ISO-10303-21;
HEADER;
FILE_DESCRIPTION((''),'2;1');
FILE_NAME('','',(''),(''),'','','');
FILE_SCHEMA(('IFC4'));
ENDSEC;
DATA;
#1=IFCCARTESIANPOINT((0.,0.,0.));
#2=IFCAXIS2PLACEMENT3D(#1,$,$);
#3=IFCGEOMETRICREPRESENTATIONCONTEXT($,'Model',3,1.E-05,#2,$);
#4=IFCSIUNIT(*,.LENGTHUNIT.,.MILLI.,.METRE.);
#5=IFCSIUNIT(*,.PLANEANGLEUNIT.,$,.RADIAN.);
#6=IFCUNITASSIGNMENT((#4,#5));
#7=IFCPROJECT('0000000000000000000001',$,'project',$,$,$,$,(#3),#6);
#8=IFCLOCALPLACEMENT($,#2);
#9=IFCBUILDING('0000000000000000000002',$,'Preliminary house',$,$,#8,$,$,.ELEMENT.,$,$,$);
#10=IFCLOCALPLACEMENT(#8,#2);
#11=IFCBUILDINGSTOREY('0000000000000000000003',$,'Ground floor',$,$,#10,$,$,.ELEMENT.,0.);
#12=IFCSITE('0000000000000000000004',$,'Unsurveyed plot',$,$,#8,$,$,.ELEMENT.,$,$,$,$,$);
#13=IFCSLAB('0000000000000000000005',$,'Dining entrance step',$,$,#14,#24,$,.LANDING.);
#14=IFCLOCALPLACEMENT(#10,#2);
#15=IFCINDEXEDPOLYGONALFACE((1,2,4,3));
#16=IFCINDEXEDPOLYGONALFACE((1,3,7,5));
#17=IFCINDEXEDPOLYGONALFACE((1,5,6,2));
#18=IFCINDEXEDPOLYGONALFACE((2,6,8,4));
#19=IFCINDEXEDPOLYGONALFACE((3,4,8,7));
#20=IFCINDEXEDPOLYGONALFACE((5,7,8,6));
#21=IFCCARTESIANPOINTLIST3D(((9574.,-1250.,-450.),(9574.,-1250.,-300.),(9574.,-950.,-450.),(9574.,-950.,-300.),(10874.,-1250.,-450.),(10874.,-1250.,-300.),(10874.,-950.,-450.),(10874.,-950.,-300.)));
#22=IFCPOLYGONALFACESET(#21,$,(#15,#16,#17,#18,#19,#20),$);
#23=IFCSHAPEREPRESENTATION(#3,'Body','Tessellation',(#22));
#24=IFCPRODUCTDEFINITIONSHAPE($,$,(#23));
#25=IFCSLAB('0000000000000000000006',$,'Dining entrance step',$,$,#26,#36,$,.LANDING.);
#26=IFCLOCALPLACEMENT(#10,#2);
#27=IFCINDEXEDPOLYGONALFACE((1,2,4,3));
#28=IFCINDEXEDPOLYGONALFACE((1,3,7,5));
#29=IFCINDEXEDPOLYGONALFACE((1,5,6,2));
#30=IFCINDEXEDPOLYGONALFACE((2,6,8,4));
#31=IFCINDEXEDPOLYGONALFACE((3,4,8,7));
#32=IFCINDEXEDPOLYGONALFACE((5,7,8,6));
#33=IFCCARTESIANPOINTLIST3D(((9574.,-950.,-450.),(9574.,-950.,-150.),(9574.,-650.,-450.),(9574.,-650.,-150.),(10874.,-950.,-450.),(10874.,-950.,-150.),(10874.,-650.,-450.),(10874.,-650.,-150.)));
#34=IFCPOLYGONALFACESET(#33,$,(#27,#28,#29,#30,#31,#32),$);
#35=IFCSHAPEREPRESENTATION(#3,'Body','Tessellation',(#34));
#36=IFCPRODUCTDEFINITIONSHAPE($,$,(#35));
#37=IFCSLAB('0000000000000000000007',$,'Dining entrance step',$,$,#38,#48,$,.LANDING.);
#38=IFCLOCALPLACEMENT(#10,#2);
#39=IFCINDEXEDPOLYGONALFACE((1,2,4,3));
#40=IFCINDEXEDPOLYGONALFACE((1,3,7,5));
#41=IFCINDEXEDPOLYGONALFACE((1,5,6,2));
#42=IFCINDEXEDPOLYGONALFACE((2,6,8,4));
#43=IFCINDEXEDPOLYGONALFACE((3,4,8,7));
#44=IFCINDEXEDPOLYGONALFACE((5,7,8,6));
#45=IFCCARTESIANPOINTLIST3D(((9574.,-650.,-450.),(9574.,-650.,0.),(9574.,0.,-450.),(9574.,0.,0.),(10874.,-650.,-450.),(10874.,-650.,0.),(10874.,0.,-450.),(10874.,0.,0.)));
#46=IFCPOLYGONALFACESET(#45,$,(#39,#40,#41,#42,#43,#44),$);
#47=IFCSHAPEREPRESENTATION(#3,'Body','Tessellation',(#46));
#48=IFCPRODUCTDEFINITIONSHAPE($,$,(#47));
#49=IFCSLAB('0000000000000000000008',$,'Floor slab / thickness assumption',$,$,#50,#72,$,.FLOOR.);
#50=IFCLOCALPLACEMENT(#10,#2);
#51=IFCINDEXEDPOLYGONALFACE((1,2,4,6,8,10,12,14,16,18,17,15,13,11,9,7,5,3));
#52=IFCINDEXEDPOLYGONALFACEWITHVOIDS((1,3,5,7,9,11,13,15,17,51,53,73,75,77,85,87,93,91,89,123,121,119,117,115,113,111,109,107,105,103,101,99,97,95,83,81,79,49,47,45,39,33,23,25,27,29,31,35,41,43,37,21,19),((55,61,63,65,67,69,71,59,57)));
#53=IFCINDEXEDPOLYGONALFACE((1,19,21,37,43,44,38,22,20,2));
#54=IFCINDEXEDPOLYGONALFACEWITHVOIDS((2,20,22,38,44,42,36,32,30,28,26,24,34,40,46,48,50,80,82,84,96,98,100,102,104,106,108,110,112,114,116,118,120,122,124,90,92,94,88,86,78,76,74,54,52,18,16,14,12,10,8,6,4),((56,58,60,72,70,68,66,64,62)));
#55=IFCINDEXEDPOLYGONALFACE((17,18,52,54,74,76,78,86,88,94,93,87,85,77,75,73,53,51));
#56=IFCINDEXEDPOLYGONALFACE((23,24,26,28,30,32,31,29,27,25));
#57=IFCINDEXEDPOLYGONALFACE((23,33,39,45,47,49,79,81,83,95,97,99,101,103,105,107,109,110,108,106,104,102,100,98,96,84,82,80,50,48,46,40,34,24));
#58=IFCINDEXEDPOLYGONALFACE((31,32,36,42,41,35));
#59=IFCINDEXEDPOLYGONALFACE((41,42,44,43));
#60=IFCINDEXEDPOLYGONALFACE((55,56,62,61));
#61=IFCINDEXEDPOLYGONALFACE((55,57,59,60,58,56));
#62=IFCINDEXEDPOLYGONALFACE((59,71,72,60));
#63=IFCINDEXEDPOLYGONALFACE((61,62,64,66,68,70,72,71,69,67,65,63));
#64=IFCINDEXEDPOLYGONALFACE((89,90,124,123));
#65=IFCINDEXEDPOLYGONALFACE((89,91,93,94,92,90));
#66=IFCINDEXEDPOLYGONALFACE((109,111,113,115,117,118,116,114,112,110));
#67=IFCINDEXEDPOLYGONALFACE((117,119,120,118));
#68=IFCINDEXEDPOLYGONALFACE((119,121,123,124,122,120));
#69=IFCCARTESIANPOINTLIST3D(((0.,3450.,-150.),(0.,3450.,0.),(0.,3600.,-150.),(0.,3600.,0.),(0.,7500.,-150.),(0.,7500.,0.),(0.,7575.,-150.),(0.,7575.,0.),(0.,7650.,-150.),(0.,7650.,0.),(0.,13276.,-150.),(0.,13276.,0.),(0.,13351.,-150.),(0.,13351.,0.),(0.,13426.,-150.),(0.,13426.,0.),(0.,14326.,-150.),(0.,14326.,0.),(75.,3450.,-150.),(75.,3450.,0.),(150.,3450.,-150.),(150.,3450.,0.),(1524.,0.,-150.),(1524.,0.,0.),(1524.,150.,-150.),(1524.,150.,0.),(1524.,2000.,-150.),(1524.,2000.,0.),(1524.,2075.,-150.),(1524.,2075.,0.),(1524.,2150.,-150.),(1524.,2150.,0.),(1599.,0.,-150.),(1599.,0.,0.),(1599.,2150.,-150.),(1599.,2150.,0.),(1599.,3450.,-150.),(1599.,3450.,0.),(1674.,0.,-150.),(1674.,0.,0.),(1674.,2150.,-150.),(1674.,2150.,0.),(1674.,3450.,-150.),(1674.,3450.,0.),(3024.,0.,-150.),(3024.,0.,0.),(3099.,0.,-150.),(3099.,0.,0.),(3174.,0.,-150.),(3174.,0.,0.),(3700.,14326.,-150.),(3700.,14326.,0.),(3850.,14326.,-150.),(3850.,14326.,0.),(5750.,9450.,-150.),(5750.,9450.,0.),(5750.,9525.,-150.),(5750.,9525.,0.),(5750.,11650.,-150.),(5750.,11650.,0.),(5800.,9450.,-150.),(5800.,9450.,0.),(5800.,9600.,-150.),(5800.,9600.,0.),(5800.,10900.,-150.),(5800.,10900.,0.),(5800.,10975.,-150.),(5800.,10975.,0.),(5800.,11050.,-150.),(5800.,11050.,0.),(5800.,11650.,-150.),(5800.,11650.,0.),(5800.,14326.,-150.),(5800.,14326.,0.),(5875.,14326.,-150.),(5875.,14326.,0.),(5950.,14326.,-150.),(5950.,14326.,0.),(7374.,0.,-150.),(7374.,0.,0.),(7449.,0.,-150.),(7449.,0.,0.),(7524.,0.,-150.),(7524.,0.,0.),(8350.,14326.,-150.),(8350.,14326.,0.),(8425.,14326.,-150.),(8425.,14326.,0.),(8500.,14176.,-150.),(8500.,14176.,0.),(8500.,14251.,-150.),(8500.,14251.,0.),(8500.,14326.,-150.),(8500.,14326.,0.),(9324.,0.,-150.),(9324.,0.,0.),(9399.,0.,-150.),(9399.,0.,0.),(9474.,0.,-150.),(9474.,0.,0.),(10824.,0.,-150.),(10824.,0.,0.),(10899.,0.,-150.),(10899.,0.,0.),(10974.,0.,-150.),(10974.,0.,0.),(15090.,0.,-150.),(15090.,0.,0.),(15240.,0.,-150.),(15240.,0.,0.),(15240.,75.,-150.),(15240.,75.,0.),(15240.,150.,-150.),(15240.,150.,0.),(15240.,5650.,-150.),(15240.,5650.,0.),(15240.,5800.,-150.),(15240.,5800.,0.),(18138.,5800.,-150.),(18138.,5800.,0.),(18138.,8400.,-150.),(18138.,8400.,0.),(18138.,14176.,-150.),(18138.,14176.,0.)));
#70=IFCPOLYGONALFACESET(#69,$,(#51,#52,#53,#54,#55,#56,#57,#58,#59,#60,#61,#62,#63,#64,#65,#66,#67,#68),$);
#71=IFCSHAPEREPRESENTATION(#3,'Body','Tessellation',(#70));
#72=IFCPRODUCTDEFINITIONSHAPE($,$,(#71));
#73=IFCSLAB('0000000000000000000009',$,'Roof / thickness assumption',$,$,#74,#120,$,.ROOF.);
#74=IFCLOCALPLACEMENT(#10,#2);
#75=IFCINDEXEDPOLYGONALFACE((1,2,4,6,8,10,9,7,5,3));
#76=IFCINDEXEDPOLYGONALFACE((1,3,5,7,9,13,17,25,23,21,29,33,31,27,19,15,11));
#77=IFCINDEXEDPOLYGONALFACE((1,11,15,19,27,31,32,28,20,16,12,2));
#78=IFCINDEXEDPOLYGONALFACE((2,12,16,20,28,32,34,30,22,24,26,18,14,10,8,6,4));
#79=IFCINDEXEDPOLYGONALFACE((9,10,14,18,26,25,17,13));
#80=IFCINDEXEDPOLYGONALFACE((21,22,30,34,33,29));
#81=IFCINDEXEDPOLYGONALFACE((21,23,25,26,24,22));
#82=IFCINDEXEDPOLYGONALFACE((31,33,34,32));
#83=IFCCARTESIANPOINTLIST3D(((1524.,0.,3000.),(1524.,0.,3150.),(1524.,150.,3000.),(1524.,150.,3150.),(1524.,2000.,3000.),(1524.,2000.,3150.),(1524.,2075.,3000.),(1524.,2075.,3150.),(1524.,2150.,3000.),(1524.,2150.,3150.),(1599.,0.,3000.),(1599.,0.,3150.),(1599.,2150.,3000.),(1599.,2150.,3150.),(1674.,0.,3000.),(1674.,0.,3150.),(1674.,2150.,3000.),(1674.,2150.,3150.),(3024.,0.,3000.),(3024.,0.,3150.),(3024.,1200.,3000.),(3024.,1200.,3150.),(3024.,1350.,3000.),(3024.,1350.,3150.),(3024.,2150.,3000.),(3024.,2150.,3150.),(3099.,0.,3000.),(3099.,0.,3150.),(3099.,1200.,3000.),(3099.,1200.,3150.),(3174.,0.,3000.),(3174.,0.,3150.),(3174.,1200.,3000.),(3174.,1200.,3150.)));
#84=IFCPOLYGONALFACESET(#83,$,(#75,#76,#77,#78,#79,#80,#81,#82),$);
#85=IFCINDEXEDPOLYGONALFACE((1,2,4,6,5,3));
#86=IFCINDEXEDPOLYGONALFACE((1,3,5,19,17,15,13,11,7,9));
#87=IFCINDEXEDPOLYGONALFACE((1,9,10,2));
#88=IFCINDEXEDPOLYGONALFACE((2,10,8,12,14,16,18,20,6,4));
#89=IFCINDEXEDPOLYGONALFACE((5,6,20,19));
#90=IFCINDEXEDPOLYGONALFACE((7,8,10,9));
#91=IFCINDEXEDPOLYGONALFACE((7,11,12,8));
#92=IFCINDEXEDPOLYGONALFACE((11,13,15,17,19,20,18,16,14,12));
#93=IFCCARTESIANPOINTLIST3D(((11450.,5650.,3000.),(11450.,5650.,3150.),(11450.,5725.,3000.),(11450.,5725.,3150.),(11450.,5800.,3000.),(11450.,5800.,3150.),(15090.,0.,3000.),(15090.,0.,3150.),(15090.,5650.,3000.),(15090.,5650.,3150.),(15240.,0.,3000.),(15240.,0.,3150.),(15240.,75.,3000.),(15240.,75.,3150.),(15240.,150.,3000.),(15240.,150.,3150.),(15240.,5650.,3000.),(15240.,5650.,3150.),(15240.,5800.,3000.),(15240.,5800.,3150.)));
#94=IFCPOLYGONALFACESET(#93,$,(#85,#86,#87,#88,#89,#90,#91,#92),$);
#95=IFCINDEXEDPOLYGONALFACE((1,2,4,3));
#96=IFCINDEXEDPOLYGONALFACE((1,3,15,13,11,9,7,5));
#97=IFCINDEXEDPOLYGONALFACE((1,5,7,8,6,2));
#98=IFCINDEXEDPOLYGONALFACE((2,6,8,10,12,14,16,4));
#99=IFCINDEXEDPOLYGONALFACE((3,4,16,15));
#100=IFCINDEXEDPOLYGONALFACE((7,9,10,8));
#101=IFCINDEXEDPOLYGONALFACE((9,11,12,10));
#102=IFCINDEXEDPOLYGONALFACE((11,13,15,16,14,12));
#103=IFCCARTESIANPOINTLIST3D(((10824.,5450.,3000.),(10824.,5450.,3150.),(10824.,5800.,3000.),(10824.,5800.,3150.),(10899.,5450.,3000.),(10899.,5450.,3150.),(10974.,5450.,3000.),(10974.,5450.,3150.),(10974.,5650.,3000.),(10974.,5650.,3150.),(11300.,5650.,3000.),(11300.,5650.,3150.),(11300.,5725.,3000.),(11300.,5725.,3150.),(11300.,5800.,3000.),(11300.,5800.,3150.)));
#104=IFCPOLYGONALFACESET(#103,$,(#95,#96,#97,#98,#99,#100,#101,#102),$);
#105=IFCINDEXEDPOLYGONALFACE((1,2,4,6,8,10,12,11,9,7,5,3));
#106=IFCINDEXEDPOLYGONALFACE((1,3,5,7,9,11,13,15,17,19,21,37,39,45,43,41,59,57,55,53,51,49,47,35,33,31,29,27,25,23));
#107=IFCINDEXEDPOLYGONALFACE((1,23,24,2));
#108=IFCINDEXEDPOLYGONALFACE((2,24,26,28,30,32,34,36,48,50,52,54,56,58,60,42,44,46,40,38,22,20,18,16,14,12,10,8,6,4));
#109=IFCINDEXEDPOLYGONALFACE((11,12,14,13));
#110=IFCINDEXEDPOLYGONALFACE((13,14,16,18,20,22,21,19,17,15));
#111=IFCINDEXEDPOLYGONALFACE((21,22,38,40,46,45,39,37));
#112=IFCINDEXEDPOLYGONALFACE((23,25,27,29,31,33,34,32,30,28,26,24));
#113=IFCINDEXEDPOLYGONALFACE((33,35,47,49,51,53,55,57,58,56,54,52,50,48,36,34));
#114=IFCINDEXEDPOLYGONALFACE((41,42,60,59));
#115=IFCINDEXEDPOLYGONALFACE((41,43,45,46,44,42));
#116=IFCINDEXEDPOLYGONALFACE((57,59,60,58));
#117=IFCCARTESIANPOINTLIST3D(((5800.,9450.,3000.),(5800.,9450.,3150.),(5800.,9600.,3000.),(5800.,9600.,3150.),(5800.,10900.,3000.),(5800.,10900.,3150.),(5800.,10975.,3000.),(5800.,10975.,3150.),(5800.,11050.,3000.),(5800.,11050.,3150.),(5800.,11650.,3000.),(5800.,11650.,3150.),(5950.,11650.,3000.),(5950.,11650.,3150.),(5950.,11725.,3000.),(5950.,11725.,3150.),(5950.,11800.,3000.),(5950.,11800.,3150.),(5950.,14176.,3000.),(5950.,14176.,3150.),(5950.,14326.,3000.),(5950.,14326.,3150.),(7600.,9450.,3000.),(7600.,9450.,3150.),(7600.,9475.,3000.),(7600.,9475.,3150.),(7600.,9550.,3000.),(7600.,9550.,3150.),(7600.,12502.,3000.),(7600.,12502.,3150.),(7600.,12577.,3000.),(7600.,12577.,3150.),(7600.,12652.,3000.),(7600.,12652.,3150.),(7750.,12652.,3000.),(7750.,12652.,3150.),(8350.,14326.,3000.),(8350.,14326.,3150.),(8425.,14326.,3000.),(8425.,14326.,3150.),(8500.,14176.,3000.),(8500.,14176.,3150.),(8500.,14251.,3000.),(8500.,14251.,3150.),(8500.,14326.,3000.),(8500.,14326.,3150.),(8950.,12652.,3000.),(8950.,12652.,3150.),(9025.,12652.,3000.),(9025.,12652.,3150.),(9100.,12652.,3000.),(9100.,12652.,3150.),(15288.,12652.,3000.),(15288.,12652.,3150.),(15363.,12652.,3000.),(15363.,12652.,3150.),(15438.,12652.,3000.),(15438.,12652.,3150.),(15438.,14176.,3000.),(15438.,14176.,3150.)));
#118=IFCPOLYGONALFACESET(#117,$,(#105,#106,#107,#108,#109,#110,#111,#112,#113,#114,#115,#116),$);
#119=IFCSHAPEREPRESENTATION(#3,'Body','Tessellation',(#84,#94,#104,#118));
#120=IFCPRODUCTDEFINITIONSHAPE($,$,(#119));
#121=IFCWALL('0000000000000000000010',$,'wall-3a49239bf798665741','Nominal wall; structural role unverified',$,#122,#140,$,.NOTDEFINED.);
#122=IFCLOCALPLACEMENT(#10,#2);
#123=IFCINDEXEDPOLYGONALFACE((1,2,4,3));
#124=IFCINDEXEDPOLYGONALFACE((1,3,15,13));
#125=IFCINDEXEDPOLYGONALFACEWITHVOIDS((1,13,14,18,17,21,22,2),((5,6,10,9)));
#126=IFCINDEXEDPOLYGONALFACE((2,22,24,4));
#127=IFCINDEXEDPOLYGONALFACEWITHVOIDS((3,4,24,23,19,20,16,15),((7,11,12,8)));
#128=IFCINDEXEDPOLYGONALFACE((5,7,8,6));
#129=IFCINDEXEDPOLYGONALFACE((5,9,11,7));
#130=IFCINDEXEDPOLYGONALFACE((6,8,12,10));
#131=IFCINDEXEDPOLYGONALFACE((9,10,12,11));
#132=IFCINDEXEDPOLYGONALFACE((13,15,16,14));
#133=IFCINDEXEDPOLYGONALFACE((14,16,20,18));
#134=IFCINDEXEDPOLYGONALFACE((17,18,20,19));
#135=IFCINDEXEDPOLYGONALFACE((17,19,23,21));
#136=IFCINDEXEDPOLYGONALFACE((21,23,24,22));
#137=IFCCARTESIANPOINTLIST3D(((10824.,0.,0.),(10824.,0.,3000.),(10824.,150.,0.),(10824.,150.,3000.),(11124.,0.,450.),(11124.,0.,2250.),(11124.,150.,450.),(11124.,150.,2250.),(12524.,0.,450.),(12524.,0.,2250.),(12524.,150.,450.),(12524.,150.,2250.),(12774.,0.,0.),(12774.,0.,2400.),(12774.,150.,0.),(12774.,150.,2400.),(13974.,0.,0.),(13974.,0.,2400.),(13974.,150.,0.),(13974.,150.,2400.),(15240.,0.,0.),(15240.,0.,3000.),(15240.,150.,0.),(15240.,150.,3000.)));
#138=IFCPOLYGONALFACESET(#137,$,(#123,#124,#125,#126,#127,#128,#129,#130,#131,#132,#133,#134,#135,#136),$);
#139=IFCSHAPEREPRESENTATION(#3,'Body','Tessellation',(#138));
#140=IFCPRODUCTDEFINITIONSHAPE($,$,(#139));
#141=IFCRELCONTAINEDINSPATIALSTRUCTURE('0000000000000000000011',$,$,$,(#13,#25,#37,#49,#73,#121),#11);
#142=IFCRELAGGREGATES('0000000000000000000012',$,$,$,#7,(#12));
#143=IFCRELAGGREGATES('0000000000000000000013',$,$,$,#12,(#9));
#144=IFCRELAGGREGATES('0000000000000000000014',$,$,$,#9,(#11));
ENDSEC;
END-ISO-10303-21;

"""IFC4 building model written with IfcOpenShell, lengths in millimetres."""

from ifc_helpers import new_model, si_unit, frame, origin, place, context, project, spatial, polyline, outline, extrude, element, save


model = new_model("IFC4")

# Units and contexts
model_context = context("Model", 3, precision=1e-05, world=origin())
ifc_project = project(units=[si_unit("LENGTHUNIT", "METRE", prefix="MILLI"), si_unit("PLANEANGLEUNIT", "RADIAN")], contexts=[model_context])

# Site, building, storey
placement_1 = place(None, origin())
site = spatial("IfcSite", under=ifc_project, at=placement_1, Name="Unsurveyed plot", CompositionType="ELEMENT")
building = spatial("IfcBuilding", under=site, at=placement_1, Name="Preliminary house", CompositionType="ELEMENT")
placement_2 = place(placement_1, origin())
storey = spatial("IfcBuildingStorey", under=building, at=placement_2, Name="Ground floor", CompositionType="ELEMENT", Elevation=0.0)

# Slabs
element("IfcSlab", 1, at=placement_2, inside=storey, Name="Dining entrance step", PredefinedType="LANDING", context=model_context, shape_type="SweptSolid", body=[
    extrude(outline(polyline([(9574.0, -1250.0), (10874.0, -1250.0), (10874.0, -950.0), (9574.0, -950.0), (9574.0, -1250.0)])), frame((0.0, 0.0, -450.0)), (0.0, 0.0, 1.0), 150.0),
])
element("IfcSlab", 2, at=placement_2, inside=storey, Name="Dining entrance step", PredefinedType="LANDING", context=model_context, shape_type="SweptSolid", body=[
    extrude(outline(polyline([(9574.0, -950.0), (10874.0, -950.0), (10874.0, -650.0), (9574.0, -650.0), (9574.0, -950.0)])), frame((0.0, 0.0, -450.0)), (0.0, 0.0, 1.0), 300.0),
])
element("IfcSlab", 3, at=placement_2, inside=storey, Name="Dining entrance step", PredefinedType="LANDING", context=model_context, shape_type="SweptSolid", body=[
    extrude(outline(polyline([(9574.0, -650.0), (10874.0, -650.0), (10874.0, 0.0), (9574.0, 0.0), (9574.0, -650.0)])), frame((0.0, 0.0, -450.0)), (0.0, 0.0, 1.0), 450.0),
])
element("IfcSlab", 4, at=placement_2, inside=storey, Name="Floor slab / thickness assumption", PredefinedType="FLOOR", context=model_context, shape_type="SweptSolid", body=[
    extrude(outline(polyline([(1599.0, 0.0), (1524.0, 0.0), (1524.0, 150.0), (1524.0, 2000.0), (1524.0, 2075.0), (1524.0, 2150.0), (1599.0, 2150.0), (1674.0, 2150.0), (1674.0, 3450.0), (1599.0, 3450.0), (150.0, 3450.0), (75.0, 3450.0), (0.0, 3450.0), (0.0, 3600.0), (0.0, 7500.0), (0.0, 7575.0), (0.0, 7650.0), (0.0, 13276.0), (0.0, 13351.0), (0.0, 13426.0), (0.0, 14326.0), (3700.0, 14326.0), (3850.0, 14326.0), (5800.0, 14326.0), (5875.0, 14326.0), (5950.0, 14326.0), (8350.0, 14326.0), (8425.0, 14326.0), (8500.0, 14326.0), (8500.0, 14251.0), (8500.0, 14176.0), (18138.0, 14176.0), (18138.0, 8400.0), (18138.0, 5800.0), (15240.0, 5800.0), (15240.0, 5650.0), (15240.0, 150.0), (15240.0, 75.0), (15240.0, 0.0), (15090.0, 0.0), (10974.0, 0.0), (10899.0, 0.0), (10824.0, 0.0), (9474.0, 0.0), (9399.0, 0.0), (9324.0, 0.0), (7524.0, 0.0), (7449.0, 0.0), (7374.0, 0.0), (3174.0, 0.0), (3099.0, 0.0), (3024.0, 0.0), (1674.0, 0.0), (1599.0, 0.0)]), holes=[polyline([(5800.0, 9600.0), (5800.0, 10900.0), (5800.0, 10975.0), (5800.0, 11050.0), (5800.0, 11650.0), (5750.0, 11650.0), (5750.0, 9525.0), (5750.0, 9450.0), (5800.0, 9450.0), (5800.0, 9600.0)])]), frame((0.0, 0.0, -150.0)), (0.0, 0.0, 1.0), 150.0),
])
element("IfcSlab", 5, at=placement_2, inside=storey, Name="Roof / thickness assumption", PredefinedType="ROOF", context=model_context, shape_type="SweptSolid", body=[
    extrude(outline(polyline([(1674.0, 2150.0), (3024.0, 2150.0), (3024.0, 1350.0), (3024.0, 1200.0), (3099.0, 1200.0), (3174.0, 1200.0), (3174.0, 0.0), (3099.0, 0.0), (3024.0, 0.0), (1674.0, 0.0), (1599.0, 0.0), (1524.0, 0.0), (1524.0, 150.0), (1524.0, 2000.0), (1524.0, 2075.0), (1524.0, 2150.0), (1599.0, 2150.0), (1674.0, 2150.0)])), frame((0.0, 0.0, 3000.0)), (0.0, 0.0, 1.0), 150.0),
    extrude(outline(polyline([(15240.0, 75.0), (15240.0, 0.0), (15090.0, 0.0), (15090.0, 5650.0), (11450.0, 5650.0), (11450.0, 5725.0), (11450.0, 5800.0), (15240.0, 5800.0), (15240.0, 5650.0), (15240.0, 150.0), (15240.0, 75.0)])), frame((0.0, 0.0, 3000.0)), (0.0, 0.0, 1.0), 150.0),
    extrude(outline(polyline([(11300.0, 5650.0), (10974.0, 5650.0), (10974.0, 5450.0), (10899.0, 5450.0), (10824.0, 5450.0), (10824.0, 5800.0), (11300.0, 5800.0), (11300.0, 5725.0), (11300.0, 5650.0)])), frame((0.0, 0.0, 3000.0)), (0.0, 0.0, 1.0), 150.0),
    extrude(outline(polyline([(8500.0, 14326.0), (8500.0, 14251.0), (8500.0, 14176.0), (15438.0, 14176.0), (15438.0, 12652.0), (15363.0, 12652.0), (15288.0, 12652.0), (9100.0, 12652.0), (9025.0, 12652.0), (8950.0, 12652.0), (7750.0, 12652.0), (7600.0, 12652.0), (7600.0, 12577.0), (7600.0, 12502.0), (7600.0, 9550.0), (7600.0, 9475.0), (7600.0, 9450.0), (5800.0, 9450.0), (5800.0, 9600.0), (5800.0, 10900.0), (5800.0, 10975.0), (5800.0, 11050.0), (5800.0, 11650.0), (5950.0, 11650.0), (5950.0, 11725.0), (5950.0, 11800.0), (5950.0, 14176.0), (5950.0, 14326.0), (8350.0, 14326.0), (8425.0, 14326.0), (8500.0, 14326.0)])), frame((0.0, 0.0, 3000.0)), (0.0, 0.0, 1.0), 150.0),
])

# Wall, openings
wall_1 = element("IfcWall", 6, at=placement_2, inside=storey, Name="wall-3a49239bf798665741", Description="Nominal wall; structural role unverified", PredefinedType="NOTDEFINED", context=model_context, shape_type="SweptSolid", body=[
    extrude(outline(polyline([(15165.0, 150.0), (15240.0, 150.0), (15240.0, 0.0), (10899.0, 0.0), (10824.0, 0.0), (10824.0, 150.0), (15165.0, 150.0)])), origin(), (0.0, 0.0, 1.0), 3000.0),
])
element("IfcOpeningElement", 7, at=placement_2, cuts=wall_1, PredefinedType="OPENING", context=model_context, shape_type="SweptSolid", body=[
    extrude(outline(polyline([(11124.0, -375.0), (12524.0, -375.0), (12524.0, 525.0), (11124.0, 525.0), (11124.0, -375.0)])), frame((0.0, 0.0, 450.0)), (0.0, 0.0, 1.0), 1800.0),
])
element("IfcOpeningElement", 8, at=placement_2, cuts=wall_1, PredefinedType="OPENING", context=model_context, shape_type="SweptSolid", body=[
    extrude(outline(polyline([(12774.0, -375.0), (13974.0, -375.0), (13974.0, 525.0), (12774.0, 525.0), (12774.0, -375.0)])), origin(), (0.0, 0.0, 1.0), 2400.0),
])

save(model, "model.ifc")
